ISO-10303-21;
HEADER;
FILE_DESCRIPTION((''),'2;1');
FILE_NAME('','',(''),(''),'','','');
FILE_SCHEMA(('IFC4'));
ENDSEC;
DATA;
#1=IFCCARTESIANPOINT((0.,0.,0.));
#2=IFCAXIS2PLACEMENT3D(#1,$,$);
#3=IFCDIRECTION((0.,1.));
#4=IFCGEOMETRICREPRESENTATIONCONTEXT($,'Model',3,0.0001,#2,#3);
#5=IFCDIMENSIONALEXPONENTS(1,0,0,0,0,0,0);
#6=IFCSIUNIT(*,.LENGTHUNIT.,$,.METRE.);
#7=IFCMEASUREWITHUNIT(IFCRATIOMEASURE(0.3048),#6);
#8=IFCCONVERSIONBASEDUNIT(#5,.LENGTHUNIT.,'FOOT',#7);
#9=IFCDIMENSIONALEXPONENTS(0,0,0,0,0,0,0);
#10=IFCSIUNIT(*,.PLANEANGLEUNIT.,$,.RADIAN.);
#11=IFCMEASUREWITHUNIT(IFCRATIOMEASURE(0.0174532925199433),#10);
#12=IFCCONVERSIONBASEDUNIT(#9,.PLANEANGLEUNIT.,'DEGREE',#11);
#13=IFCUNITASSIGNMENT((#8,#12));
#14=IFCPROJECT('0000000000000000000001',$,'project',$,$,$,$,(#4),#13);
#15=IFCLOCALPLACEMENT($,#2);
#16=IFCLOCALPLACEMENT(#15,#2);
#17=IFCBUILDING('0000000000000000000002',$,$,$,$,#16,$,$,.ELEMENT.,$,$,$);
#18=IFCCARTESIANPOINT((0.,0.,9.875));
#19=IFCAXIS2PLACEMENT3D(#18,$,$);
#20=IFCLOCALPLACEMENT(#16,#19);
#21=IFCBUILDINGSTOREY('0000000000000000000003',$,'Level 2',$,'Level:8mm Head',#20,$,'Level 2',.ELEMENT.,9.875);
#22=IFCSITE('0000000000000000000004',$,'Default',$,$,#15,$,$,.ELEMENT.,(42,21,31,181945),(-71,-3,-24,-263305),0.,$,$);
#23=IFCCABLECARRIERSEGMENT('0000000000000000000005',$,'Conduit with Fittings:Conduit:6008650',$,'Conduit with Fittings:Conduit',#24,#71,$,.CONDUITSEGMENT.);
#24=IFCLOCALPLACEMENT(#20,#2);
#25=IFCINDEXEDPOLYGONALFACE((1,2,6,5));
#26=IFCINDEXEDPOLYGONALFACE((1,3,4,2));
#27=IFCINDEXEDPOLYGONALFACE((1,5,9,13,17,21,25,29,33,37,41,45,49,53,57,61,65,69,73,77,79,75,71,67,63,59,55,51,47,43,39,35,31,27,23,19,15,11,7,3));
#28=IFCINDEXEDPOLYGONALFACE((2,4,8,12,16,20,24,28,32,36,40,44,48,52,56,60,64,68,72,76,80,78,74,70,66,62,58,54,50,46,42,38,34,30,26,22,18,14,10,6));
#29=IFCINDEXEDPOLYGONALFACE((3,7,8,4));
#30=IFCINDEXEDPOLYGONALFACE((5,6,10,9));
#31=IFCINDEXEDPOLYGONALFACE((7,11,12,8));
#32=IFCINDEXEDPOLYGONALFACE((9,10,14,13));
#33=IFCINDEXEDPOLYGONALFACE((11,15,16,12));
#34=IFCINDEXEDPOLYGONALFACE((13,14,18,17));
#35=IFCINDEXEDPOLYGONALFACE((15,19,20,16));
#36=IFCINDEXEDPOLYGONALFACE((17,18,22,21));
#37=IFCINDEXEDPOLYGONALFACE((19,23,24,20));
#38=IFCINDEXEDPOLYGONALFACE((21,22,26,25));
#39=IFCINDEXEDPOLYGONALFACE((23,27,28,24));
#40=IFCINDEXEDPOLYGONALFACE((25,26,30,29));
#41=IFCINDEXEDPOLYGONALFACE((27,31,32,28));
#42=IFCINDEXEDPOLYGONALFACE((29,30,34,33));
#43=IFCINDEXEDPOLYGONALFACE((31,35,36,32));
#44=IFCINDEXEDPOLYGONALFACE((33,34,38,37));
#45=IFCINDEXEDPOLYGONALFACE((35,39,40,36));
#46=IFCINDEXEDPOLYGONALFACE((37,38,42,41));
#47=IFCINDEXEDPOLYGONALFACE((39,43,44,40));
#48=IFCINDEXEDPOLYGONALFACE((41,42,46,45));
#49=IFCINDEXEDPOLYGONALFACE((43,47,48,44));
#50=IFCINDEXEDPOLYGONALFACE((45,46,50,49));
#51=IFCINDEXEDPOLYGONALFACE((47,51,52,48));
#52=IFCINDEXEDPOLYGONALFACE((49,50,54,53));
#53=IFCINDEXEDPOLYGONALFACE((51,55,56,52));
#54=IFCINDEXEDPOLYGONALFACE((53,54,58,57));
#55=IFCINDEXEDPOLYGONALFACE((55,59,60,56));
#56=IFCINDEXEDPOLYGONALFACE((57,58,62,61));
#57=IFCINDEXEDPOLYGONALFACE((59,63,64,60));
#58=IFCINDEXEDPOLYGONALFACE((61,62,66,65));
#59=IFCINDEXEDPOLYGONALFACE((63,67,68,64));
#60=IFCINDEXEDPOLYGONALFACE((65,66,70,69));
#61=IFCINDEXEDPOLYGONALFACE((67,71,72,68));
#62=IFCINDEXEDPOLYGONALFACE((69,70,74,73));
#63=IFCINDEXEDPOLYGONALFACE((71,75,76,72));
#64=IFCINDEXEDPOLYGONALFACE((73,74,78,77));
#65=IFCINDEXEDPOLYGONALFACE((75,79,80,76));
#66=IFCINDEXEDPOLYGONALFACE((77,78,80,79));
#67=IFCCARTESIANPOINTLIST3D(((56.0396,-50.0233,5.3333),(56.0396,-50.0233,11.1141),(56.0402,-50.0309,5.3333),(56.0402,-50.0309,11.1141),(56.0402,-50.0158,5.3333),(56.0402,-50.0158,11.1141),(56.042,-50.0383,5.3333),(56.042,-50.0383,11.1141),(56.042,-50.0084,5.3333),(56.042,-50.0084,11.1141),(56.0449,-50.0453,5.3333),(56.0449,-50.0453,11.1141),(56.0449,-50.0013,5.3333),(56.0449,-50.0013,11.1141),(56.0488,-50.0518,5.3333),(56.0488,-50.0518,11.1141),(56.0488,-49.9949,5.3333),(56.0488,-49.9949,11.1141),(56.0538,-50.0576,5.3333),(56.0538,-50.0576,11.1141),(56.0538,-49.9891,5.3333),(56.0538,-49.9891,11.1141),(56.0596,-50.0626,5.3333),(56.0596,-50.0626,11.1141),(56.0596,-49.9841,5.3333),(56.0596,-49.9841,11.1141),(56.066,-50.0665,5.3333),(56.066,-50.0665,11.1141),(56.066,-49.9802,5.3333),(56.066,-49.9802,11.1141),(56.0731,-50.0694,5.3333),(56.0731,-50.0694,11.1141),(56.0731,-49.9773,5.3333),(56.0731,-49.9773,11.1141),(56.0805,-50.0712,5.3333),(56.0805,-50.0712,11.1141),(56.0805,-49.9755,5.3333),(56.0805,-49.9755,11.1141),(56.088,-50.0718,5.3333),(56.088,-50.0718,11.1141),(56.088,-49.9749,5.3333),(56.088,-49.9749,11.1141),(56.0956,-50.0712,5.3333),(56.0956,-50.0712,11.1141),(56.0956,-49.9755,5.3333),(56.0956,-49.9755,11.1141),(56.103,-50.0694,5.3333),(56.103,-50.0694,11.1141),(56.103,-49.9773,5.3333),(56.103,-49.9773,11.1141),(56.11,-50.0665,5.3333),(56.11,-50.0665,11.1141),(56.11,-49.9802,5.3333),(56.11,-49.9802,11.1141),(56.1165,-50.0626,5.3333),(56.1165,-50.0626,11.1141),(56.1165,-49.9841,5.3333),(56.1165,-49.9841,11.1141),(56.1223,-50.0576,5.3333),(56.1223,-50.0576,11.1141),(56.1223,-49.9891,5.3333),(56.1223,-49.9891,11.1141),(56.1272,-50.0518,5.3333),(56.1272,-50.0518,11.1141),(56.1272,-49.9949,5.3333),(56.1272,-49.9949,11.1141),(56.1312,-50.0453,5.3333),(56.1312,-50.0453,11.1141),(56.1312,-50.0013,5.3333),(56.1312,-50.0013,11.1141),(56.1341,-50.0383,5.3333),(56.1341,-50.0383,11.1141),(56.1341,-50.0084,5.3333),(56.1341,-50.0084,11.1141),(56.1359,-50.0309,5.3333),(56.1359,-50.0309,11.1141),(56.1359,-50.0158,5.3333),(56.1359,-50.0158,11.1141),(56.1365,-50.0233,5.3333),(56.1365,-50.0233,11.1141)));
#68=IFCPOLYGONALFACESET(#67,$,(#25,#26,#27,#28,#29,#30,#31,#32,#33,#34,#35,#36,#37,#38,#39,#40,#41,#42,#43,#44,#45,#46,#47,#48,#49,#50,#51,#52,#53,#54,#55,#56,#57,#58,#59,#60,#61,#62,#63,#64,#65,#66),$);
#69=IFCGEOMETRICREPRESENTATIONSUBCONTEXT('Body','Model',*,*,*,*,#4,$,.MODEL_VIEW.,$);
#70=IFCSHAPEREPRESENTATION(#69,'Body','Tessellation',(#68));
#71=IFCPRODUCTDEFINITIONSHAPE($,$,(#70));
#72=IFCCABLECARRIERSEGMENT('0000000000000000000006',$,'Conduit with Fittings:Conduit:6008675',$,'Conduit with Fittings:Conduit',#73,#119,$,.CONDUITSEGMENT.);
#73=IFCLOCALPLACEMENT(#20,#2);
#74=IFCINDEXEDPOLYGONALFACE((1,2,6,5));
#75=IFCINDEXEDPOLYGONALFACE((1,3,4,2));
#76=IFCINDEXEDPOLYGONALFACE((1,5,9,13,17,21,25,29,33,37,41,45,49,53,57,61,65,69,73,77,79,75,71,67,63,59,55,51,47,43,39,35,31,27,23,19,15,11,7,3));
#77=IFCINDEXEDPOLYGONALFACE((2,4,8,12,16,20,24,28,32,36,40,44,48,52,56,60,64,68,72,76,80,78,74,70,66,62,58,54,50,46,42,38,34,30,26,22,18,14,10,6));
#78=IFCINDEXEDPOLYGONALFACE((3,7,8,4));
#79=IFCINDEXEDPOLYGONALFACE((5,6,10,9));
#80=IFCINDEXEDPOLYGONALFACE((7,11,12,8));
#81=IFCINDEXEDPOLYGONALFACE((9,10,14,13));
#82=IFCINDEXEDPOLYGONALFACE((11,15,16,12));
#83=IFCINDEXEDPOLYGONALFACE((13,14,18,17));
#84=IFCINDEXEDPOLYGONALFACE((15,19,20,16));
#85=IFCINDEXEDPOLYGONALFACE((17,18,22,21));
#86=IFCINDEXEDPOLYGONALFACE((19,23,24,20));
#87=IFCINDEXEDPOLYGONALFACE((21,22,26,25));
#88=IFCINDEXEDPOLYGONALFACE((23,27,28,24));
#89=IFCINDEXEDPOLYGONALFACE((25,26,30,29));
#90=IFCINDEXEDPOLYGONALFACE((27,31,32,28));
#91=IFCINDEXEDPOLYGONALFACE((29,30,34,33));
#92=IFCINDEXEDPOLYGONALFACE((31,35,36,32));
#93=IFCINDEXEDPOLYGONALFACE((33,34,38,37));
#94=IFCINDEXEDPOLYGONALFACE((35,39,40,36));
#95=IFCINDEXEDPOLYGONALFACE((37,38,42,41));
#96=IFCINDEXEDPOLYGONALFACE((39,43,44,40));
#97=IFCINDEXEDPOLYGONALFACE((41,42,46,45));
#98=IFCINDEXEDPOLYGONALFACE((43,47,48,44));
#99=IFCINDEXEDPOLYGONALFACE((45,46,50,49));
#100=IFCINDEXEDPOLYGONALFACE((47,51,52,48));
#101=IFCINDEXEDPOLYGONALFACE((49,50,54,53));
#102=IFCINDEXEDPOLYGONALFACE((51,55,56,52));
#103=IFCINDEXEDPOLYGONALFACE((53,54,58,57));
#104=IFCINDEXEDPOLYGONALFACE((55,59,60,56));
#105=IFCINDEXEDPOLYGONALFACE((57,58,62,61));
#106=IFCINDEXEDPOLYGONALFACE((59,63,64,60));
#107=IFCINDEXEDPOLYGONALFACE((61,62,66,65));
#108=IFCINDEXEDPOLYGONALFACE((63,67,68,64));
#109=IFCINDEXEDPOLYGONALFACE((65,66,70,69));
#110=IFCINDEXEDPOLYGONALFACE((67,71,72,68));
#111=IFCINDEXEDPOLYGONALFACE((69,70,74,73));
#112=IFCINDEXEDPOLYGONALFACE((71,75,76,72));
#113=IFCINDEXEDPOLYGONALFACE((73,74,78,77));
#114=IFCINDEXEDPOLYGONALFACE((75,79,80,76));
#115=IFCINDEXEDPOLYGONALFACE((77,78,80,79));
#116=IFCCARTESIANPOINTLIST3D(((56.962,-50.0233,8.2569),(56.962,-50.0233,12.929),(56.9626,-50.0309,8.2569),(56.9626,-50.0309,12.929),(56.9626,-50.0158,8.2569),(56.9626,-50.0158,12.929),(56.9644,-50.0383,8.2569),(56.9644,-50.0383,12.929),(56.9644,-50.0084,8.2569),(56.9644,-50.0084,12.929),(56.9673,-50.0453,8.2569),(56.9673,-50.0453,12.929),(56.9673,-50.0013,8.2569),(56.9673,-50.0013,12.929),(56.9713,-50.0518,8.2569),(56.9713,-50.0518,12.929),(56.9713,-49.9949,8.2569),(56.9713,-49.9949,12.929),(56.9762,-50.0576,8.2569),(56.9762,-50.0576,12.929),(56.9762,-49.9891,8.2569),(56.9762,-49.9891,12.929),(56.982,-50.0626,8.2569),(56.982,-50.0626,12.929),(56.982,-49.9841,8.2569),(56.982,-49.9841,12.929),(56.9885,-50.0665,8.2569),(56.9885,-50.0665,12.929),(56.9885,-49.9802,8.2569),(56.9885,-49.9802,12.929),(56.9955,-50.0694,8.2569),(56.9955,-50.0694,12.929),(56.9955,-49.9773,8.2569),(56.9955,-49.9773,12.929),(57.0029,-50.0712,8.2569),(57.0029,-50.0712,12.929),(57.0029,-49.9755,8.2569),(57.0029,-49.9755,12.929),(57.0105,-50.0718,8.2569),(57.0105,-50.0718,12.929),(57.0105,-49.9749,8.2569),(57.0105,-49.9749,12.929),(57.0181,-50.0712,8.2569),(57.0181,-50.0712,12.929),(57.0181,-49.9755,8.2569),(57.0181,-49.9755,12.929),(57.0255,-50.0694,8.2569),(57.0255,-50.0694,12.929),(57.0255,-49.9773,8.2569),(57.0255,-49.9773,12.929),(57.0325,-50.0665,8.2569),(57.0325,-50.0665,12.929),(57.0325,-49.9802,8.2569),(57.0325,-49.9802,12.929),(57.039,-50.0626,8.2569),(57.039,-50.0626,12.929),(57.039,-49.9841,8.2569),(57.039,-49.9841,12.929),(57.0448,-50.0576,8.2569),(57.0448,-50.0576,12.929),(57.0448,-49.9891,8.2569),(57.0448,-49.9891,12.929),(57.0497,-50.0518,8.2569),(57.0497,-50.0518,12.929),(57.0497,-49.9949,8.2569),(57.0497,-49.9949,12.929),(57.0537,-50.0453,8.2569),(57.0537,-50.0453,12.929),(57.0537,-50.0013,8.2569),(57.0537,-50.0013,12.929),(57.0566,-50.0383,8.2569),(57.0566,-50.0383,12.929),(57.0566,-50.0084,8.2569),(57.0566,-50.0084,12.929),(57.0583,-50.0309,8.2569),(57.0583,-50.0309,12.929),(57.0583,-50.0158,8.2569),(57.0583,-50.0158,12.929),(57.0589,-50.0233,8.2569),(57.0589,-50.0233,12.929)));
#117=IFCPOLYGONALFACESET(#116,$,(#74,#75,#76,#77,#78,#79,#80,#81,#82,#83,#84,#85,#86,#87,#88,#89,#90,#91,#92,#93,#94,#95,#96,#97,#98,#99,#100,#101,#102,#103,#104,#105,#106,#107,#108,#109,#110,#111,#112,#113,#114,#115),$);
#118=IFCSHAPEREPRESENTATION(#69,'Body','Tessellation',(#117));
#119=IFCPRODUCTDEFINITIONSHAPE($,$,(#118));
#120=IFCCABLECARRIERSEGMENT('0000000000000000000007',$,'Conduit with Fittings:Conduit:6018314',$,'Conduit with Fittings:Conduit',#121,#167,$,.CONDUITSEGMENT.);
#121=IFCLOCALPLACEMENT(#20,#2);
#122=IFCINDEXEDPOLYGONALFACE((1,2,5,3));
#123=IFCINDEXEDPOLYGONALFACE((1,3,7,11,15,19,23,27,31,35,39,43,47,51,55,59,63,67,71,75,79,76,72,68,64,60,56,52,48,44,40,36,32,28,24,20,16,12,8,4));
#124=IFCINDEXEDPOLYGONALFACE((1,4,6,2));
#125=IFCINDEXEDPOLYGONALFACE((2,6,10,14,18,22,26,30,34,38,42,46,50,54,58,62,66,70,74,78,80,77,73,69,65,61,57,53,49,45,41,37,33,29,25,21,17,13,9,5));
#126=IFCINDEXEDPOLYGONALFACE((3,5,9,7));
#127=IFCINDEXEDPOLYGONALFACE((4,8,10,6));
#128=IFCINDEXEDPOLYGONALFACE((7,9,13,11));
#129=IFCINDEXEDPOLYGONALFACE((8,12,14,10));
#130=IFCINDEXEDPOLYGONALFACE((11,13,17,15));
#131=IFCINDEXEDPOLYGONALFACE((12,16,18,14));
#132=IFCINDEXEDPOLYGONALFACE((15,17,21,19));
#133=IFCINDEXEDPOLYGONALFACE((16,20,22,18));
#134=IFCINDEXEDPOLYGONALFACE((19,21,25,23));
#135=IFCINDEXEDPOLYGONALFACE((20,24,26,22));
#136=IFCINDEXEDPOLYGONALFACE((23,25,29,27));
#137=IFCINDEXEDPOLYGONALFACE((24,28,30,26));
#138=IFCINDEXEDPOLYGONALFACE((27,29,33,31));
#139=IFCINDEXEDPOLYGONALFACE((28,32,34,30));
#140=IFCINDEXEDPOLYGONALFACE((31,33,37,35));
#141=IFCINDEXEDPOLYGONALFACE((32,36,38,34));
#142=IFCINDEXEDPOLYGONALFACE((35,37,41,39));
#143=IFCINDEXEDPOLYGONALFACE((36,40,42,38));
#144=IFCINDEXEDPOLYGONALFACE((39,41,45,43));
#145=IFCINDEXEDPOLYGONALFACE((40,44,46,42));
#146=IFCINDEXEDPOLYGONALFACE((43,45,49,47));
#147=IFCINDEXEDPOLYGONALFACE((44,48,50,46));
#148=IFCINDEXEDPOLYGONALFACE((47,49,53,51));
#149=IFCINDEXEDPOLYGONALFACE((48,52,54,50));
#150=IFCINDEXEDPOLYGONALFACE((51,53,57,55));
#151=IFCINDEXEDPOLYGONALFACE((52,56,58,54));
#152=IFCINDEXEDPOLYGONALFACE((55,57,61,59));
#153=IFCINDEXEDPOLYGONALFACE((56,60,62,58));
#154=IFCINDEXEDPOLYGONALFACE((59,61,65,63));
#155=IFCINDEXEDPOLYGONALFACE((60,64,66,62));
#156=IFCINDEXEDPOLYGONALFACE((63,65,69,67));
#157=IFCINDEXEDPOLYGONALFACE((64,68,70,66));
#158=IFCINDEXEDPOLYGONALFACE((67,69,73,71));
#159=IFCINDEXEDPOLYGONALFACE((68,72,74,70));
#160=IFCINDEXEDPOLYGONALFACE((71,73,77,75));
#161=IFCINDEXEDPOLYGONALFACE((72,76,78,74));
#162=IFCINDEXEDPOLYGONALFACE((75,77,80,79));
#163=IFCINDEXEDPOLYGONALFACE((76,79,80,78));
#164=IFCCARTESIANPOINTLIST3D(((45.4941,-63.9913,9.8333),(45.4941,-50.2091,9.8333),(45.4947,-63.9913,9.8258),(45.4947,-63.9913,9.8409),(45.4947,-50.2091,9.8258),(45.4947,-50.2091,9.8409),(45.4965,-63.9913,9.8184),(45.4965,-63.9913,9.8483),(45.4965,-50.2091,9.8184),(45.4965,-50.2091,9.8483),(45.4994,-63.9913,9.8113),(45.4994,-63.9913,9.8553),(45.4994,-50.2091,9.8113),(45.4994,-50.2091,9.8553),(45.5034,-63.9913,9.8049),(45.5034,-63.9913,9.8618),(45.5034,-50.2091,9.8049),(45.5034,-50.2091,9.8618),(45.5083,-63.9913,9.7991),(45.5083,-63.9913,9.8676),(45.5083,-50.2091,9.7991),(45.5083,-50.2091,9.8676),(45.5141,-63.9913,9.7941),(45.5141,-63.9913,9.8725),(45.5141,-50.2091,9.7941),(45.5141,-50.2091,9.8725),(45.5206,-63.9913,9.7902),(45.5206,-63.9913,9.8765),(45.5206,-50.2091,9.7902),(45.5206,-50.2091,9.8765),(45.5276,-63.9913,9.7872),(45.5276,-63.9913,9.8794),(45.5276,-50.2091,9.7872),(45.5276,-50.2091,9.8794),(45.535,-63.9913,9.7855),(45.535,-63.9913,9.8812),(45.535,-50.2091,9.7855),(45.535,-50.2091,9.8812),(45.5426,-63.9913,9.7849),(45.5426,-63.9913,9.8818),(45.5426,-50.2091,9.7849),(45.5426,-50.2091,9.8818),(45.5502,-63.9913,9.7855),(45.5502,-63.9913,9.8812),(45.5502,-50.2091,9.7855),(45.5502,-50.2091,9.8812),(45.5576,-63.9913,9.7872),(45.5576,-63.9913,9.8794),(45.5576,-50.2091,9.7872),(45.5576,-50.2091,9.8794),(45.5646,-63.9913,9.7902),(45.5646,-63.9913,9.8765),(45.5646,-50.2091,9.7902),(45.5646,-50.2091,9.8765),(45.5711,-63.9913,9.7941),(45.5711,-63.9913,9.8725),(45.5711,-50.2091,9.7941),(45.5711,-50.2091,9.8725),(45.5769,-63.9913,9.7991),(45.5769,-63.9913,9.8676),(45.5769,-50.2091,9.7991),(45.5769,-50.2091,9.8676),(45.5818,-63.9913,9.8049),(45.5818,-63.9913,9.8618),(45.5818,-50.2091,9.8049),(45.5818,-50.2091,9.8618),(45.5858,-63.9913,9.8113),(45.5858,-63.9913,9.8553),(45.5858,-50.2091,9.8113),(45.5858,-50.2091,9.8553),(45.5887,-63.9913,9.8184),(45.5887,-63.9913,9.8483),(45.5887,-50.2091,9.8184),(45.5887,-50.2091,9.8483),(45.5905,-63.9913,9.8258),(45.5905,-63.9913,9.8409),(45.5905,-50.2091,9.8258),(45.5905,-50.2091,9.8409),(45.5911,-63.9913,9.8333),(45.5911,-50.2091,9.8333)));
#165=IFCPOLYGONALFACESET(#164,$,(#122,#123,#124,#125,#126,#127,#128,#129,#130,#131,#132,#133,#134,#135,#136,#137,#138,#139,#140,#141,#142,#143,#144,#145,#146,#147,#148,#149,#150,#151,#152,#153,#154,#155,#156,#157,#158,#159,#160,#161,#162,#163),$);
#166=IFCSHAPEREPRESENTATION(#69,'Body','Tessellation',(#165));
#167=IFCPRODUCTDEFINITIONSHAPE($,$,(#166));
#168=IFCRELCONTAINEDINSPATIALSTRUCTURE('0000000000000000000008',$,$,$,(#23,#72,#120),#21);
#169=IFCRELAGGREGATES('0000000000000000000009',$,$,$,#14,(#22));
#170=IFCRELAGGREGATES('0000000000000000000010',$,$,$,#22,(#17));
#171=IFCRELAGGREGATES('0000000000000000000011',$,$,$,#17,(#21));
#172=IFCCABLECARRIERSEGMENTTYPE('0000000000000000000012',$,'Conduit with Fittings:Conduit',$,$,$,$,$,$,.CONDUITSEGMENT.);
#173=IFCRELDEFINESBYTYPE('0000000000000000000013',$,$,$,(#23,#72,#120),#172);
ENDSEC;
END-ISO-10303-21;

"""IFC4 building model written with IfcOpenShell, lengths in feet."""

from ifc_helpers import new_model, entity, si_unit, converted_unit, direction, frame, origin, place, context, subcontext, project, spatial, indexed_curve, outline, extrude, type_object, element, save


model = new_model("IFC4")

# Units and contexts
model_context = context("Model", 3, precision=0.0001, world=origin(), true_north=direction((0.0, 1.0)))
body_context = subcontext(model_context, "Body", "Model", "MODEL_VIEW")
ifc_project = project(units=[converted_unit("LENGTHUNIT", "FOOT", entity("IfcRatioMeasure", 0.3048), si_unit("LENGTHUNIT", "METRE"), dimensions=[1, 0, 0, 0, 0, 0, 0]), converted_unit("PLANEANGLEUNIT", "DEGREE", entity("IfcRatioMeasure", 0.0174532925199433), si_unit("PLANEANGLEUNIT", "RADIAN"), dimensions=[0, 0, 0, 0, 0, 0, 0])], contexts=[model_context])

# Site, building, storey
site_placement = place(None, origin())
site = spatial("IfcSite", under=ifc_project, at=site_placement, Name="Default", CompositionType="ELEMENT", RefLatitude=(42, 21, 31, 181945), RefLongitude=(-71, -3, -24, -263305), RefElevation=0.0)
building_placement = place(site_placement, origin())
building = spatial("IfcBuilding", under=site, at=building_placement, CompositionType="ELEMENT")
storey_placement = place(building_placement, frame((0.0, 0.0, 9.875)))
storey = spatial("IfcBuildingStorey", under=building, at=storey_placement, Name="Level 2", ObjectType="Level:8mm Head", LongName="Level 2", CompositionType="ELEMENT", Elevation=9.875)

# Cable carrier segments
cable_carrier_segment_type = type_object("IfcCableCarrierSegmentType", Name="Conduit with Fittings:Conduit", PredefinedType="CONDUITSEGMENT")
cable_carrier_segment_1_placement = place(storey_placement, origin())
element("IfcCableCarrierSegment", 1, at=cable_carrier_segment_1_placement, inside=storey, type_object=cable_carrier_segment_type, Name="Conduit with Fittings:Conduit:6008650", ObjectType="Conduit with Fittings:Conduit", PredefinedType="CONDUITSEGMENT", context=body_context, shape_type="SweptSolid", body=[
    extrude(outline(indexed_curve([(0.0485, 0.0), (0.0479, 0.0076), (0.0461, 0.015), (0.0432, 0.022), (0.0392, 0.0285), (0.0343, 0.0343), (0.0285, 0.0392), (0.022, 0.0432), (0.015, 0.0461), (0.0076, 0.0479), (0.0, 0.0485), (-0.0076, 0.0479), (-0.015, 0.0461), (-0.022, 0.0432), (-0.0285, 0.0392), (-0.0343, 0.0343), (-0.0392, 0.0285), (-0.0432, 0.022), (-0.0461, 0.015), (-0.0479, 0.0076), (-0.0485, 0.0), (-0.0479, -0.0076), (-0.0461, -0.015), (-0.0432, -0.022), (-0.0392, -0.0285), (-0.0343, -0.0343), (-0.0285, -0.0392), (-0.022, -0.0432), (-0.015, -0.0461), (-0.0076, -0.0479), (0.0, -0.0485), (0.0076, -0.0479), (0.015, -0.0461), (0.022, -0.0432), (0.0285, -0.0392), (0.0343, -0.0343), (0.0392, -0.0285), (0.0432, -0.022), (0.0461, -0.015), (0.0479, -0.0076), (0.0485, 0.0)], self_intersect=False)), frame((56.088, -50.0233, 5.3333), z_axis=(0.0, 0.0, 1.0), x_axis=(-1.0, 0.0, 0.0)), (0.0, 0.0, 1.0), 5.7808),
])
cable_carrier_segment_2_placement = place(storey_placement, origin())
element("IfcCableCarrierSegment", 2, at=cable_carrier_segment_2_placement, inside=storey, type_object=cable_carrier_segment_type, Name="Conduit with Fittings:Conduit:6008675", ObjectType="Conduit with Fittings:Conduit", PredefinedType="CONDUITSEGMENT", context=body_context, shape_type="SweptSolid", body=[
    extrude(outline(indexed_curve([(0.0485, 0.0), (0.0479, 0.0076), (0.0461, 0.015), (0.0432, 0.022), (0.0392, 0.0285), (0.0343, 0.0343), (0.0285, 0.0392), (0.022, 0.0432), (0.015, 0.0461), (0.0076, 0.0479), (0.0, 0.0485), (-0.0076, 0.0479), (-0.015, 0.0461), (-0.022, 0.0432), (-0.0285, 0.0392), (-0.0343, 0.0343), (-0.0392, 0.0285), (-0.0432, 0.022), (-0.0461, 0.015), (-0.0479, 0.0076), (-0.0485, 0.0), (-0.0479, -0.0076), (-0.0461, -0.015), (-0.0432, -0.022), (-0.0392, -0.0285), (-0.0343, -0.0343), (-0.0285, -0.0392), (-0.022, -0.0432), (-0.015, -0.0461), (-0.0076, -0.0479), (0.0, -0.0485), (0.0076, -0.0479), (0.015, -0.0461), (0.022, -0.0432), (0.0285, -0.0392), (0.0343, -0.0343), (0.0392, -0.0285), (0.0432, -0.022), (0.0461, -0.015), (0.0479, -0.0076), (0.0485, 0.0)], self_intersect=False)), frame((57.0105, -50.0233, 8.2569), z_axis=(0.0, 0.0, 1.0), x_axis=(-1.0, 0.0, 0.0)), (0.0, 0.0, 1.0), 4.6721),
])
cable_carrier_segment_3_placement = place(storey_placement, origin())
element("IfcCableCarrierSegment", 3, at=cable_carrier_segment_3_placement, inside=storey, type_object=cable_carrier_segment_type, Name="Conduit with Fittings:Conduit:6018314", ObjectType="Conduit with Fittings:Conduit", PredefinedType="CONDUITSEGMENT", context=body_context, shape_type="SweptSolid", body=[
    extrude(outline(indexed_curve([(0.0485, 0.0), (0.0479, 0.0076), (0.0461, 0.015), (0.0432, 0.022), (0.0392, 0.0285), (0.0343, 0.0343), (0.0285, 0.0392), (0.022, 0.0432), (0.015, 0.0461), (0.0076, 0.0479), (0.0, 0.0485), (-0.0076, 0.0479), (-0.015, 0.0461), (-0.022, 0.0432), (-0.0285, 0.0392), (-0.0343, 0.0343), (-0.0392, 0.0285), (-0.0432, 0.022), (-0.0461, 0.015), (-0.0479, 0.0076), (-0.0485, 0.0), (-0.0479, -0.0076), (-0.0461, -0.015), (-0.0432, -0.022), (-0.0392, -0.0285), (-0.0343, -0.0343), (-0.0285, -0.0392), (-0.022, -0.0432), (-0.015, -0.0461), (-0.0076, -0.0479), (0.0, -0.0485), (0.0076, -0.0479), (0.015, -0.0461), (0.022, -0.0432), (0.0285, -0.0392), (0.0343, -0.0343), (0.0392, -0.0285), (0.0432, -0.022), (0.0461, -0.015), (0.0479, -0.0076), (0.0485, 0.0)], self_intersect=False)), frame((45.5426, -63.9913, 9.8333), z_axis=(0.0, 1.0, 0.0), x_axis=(-1.0, 0.0, 0.0)), (0.0, 0.0, 1.0), 13.7822),
])

save(model, "model.ifc")
